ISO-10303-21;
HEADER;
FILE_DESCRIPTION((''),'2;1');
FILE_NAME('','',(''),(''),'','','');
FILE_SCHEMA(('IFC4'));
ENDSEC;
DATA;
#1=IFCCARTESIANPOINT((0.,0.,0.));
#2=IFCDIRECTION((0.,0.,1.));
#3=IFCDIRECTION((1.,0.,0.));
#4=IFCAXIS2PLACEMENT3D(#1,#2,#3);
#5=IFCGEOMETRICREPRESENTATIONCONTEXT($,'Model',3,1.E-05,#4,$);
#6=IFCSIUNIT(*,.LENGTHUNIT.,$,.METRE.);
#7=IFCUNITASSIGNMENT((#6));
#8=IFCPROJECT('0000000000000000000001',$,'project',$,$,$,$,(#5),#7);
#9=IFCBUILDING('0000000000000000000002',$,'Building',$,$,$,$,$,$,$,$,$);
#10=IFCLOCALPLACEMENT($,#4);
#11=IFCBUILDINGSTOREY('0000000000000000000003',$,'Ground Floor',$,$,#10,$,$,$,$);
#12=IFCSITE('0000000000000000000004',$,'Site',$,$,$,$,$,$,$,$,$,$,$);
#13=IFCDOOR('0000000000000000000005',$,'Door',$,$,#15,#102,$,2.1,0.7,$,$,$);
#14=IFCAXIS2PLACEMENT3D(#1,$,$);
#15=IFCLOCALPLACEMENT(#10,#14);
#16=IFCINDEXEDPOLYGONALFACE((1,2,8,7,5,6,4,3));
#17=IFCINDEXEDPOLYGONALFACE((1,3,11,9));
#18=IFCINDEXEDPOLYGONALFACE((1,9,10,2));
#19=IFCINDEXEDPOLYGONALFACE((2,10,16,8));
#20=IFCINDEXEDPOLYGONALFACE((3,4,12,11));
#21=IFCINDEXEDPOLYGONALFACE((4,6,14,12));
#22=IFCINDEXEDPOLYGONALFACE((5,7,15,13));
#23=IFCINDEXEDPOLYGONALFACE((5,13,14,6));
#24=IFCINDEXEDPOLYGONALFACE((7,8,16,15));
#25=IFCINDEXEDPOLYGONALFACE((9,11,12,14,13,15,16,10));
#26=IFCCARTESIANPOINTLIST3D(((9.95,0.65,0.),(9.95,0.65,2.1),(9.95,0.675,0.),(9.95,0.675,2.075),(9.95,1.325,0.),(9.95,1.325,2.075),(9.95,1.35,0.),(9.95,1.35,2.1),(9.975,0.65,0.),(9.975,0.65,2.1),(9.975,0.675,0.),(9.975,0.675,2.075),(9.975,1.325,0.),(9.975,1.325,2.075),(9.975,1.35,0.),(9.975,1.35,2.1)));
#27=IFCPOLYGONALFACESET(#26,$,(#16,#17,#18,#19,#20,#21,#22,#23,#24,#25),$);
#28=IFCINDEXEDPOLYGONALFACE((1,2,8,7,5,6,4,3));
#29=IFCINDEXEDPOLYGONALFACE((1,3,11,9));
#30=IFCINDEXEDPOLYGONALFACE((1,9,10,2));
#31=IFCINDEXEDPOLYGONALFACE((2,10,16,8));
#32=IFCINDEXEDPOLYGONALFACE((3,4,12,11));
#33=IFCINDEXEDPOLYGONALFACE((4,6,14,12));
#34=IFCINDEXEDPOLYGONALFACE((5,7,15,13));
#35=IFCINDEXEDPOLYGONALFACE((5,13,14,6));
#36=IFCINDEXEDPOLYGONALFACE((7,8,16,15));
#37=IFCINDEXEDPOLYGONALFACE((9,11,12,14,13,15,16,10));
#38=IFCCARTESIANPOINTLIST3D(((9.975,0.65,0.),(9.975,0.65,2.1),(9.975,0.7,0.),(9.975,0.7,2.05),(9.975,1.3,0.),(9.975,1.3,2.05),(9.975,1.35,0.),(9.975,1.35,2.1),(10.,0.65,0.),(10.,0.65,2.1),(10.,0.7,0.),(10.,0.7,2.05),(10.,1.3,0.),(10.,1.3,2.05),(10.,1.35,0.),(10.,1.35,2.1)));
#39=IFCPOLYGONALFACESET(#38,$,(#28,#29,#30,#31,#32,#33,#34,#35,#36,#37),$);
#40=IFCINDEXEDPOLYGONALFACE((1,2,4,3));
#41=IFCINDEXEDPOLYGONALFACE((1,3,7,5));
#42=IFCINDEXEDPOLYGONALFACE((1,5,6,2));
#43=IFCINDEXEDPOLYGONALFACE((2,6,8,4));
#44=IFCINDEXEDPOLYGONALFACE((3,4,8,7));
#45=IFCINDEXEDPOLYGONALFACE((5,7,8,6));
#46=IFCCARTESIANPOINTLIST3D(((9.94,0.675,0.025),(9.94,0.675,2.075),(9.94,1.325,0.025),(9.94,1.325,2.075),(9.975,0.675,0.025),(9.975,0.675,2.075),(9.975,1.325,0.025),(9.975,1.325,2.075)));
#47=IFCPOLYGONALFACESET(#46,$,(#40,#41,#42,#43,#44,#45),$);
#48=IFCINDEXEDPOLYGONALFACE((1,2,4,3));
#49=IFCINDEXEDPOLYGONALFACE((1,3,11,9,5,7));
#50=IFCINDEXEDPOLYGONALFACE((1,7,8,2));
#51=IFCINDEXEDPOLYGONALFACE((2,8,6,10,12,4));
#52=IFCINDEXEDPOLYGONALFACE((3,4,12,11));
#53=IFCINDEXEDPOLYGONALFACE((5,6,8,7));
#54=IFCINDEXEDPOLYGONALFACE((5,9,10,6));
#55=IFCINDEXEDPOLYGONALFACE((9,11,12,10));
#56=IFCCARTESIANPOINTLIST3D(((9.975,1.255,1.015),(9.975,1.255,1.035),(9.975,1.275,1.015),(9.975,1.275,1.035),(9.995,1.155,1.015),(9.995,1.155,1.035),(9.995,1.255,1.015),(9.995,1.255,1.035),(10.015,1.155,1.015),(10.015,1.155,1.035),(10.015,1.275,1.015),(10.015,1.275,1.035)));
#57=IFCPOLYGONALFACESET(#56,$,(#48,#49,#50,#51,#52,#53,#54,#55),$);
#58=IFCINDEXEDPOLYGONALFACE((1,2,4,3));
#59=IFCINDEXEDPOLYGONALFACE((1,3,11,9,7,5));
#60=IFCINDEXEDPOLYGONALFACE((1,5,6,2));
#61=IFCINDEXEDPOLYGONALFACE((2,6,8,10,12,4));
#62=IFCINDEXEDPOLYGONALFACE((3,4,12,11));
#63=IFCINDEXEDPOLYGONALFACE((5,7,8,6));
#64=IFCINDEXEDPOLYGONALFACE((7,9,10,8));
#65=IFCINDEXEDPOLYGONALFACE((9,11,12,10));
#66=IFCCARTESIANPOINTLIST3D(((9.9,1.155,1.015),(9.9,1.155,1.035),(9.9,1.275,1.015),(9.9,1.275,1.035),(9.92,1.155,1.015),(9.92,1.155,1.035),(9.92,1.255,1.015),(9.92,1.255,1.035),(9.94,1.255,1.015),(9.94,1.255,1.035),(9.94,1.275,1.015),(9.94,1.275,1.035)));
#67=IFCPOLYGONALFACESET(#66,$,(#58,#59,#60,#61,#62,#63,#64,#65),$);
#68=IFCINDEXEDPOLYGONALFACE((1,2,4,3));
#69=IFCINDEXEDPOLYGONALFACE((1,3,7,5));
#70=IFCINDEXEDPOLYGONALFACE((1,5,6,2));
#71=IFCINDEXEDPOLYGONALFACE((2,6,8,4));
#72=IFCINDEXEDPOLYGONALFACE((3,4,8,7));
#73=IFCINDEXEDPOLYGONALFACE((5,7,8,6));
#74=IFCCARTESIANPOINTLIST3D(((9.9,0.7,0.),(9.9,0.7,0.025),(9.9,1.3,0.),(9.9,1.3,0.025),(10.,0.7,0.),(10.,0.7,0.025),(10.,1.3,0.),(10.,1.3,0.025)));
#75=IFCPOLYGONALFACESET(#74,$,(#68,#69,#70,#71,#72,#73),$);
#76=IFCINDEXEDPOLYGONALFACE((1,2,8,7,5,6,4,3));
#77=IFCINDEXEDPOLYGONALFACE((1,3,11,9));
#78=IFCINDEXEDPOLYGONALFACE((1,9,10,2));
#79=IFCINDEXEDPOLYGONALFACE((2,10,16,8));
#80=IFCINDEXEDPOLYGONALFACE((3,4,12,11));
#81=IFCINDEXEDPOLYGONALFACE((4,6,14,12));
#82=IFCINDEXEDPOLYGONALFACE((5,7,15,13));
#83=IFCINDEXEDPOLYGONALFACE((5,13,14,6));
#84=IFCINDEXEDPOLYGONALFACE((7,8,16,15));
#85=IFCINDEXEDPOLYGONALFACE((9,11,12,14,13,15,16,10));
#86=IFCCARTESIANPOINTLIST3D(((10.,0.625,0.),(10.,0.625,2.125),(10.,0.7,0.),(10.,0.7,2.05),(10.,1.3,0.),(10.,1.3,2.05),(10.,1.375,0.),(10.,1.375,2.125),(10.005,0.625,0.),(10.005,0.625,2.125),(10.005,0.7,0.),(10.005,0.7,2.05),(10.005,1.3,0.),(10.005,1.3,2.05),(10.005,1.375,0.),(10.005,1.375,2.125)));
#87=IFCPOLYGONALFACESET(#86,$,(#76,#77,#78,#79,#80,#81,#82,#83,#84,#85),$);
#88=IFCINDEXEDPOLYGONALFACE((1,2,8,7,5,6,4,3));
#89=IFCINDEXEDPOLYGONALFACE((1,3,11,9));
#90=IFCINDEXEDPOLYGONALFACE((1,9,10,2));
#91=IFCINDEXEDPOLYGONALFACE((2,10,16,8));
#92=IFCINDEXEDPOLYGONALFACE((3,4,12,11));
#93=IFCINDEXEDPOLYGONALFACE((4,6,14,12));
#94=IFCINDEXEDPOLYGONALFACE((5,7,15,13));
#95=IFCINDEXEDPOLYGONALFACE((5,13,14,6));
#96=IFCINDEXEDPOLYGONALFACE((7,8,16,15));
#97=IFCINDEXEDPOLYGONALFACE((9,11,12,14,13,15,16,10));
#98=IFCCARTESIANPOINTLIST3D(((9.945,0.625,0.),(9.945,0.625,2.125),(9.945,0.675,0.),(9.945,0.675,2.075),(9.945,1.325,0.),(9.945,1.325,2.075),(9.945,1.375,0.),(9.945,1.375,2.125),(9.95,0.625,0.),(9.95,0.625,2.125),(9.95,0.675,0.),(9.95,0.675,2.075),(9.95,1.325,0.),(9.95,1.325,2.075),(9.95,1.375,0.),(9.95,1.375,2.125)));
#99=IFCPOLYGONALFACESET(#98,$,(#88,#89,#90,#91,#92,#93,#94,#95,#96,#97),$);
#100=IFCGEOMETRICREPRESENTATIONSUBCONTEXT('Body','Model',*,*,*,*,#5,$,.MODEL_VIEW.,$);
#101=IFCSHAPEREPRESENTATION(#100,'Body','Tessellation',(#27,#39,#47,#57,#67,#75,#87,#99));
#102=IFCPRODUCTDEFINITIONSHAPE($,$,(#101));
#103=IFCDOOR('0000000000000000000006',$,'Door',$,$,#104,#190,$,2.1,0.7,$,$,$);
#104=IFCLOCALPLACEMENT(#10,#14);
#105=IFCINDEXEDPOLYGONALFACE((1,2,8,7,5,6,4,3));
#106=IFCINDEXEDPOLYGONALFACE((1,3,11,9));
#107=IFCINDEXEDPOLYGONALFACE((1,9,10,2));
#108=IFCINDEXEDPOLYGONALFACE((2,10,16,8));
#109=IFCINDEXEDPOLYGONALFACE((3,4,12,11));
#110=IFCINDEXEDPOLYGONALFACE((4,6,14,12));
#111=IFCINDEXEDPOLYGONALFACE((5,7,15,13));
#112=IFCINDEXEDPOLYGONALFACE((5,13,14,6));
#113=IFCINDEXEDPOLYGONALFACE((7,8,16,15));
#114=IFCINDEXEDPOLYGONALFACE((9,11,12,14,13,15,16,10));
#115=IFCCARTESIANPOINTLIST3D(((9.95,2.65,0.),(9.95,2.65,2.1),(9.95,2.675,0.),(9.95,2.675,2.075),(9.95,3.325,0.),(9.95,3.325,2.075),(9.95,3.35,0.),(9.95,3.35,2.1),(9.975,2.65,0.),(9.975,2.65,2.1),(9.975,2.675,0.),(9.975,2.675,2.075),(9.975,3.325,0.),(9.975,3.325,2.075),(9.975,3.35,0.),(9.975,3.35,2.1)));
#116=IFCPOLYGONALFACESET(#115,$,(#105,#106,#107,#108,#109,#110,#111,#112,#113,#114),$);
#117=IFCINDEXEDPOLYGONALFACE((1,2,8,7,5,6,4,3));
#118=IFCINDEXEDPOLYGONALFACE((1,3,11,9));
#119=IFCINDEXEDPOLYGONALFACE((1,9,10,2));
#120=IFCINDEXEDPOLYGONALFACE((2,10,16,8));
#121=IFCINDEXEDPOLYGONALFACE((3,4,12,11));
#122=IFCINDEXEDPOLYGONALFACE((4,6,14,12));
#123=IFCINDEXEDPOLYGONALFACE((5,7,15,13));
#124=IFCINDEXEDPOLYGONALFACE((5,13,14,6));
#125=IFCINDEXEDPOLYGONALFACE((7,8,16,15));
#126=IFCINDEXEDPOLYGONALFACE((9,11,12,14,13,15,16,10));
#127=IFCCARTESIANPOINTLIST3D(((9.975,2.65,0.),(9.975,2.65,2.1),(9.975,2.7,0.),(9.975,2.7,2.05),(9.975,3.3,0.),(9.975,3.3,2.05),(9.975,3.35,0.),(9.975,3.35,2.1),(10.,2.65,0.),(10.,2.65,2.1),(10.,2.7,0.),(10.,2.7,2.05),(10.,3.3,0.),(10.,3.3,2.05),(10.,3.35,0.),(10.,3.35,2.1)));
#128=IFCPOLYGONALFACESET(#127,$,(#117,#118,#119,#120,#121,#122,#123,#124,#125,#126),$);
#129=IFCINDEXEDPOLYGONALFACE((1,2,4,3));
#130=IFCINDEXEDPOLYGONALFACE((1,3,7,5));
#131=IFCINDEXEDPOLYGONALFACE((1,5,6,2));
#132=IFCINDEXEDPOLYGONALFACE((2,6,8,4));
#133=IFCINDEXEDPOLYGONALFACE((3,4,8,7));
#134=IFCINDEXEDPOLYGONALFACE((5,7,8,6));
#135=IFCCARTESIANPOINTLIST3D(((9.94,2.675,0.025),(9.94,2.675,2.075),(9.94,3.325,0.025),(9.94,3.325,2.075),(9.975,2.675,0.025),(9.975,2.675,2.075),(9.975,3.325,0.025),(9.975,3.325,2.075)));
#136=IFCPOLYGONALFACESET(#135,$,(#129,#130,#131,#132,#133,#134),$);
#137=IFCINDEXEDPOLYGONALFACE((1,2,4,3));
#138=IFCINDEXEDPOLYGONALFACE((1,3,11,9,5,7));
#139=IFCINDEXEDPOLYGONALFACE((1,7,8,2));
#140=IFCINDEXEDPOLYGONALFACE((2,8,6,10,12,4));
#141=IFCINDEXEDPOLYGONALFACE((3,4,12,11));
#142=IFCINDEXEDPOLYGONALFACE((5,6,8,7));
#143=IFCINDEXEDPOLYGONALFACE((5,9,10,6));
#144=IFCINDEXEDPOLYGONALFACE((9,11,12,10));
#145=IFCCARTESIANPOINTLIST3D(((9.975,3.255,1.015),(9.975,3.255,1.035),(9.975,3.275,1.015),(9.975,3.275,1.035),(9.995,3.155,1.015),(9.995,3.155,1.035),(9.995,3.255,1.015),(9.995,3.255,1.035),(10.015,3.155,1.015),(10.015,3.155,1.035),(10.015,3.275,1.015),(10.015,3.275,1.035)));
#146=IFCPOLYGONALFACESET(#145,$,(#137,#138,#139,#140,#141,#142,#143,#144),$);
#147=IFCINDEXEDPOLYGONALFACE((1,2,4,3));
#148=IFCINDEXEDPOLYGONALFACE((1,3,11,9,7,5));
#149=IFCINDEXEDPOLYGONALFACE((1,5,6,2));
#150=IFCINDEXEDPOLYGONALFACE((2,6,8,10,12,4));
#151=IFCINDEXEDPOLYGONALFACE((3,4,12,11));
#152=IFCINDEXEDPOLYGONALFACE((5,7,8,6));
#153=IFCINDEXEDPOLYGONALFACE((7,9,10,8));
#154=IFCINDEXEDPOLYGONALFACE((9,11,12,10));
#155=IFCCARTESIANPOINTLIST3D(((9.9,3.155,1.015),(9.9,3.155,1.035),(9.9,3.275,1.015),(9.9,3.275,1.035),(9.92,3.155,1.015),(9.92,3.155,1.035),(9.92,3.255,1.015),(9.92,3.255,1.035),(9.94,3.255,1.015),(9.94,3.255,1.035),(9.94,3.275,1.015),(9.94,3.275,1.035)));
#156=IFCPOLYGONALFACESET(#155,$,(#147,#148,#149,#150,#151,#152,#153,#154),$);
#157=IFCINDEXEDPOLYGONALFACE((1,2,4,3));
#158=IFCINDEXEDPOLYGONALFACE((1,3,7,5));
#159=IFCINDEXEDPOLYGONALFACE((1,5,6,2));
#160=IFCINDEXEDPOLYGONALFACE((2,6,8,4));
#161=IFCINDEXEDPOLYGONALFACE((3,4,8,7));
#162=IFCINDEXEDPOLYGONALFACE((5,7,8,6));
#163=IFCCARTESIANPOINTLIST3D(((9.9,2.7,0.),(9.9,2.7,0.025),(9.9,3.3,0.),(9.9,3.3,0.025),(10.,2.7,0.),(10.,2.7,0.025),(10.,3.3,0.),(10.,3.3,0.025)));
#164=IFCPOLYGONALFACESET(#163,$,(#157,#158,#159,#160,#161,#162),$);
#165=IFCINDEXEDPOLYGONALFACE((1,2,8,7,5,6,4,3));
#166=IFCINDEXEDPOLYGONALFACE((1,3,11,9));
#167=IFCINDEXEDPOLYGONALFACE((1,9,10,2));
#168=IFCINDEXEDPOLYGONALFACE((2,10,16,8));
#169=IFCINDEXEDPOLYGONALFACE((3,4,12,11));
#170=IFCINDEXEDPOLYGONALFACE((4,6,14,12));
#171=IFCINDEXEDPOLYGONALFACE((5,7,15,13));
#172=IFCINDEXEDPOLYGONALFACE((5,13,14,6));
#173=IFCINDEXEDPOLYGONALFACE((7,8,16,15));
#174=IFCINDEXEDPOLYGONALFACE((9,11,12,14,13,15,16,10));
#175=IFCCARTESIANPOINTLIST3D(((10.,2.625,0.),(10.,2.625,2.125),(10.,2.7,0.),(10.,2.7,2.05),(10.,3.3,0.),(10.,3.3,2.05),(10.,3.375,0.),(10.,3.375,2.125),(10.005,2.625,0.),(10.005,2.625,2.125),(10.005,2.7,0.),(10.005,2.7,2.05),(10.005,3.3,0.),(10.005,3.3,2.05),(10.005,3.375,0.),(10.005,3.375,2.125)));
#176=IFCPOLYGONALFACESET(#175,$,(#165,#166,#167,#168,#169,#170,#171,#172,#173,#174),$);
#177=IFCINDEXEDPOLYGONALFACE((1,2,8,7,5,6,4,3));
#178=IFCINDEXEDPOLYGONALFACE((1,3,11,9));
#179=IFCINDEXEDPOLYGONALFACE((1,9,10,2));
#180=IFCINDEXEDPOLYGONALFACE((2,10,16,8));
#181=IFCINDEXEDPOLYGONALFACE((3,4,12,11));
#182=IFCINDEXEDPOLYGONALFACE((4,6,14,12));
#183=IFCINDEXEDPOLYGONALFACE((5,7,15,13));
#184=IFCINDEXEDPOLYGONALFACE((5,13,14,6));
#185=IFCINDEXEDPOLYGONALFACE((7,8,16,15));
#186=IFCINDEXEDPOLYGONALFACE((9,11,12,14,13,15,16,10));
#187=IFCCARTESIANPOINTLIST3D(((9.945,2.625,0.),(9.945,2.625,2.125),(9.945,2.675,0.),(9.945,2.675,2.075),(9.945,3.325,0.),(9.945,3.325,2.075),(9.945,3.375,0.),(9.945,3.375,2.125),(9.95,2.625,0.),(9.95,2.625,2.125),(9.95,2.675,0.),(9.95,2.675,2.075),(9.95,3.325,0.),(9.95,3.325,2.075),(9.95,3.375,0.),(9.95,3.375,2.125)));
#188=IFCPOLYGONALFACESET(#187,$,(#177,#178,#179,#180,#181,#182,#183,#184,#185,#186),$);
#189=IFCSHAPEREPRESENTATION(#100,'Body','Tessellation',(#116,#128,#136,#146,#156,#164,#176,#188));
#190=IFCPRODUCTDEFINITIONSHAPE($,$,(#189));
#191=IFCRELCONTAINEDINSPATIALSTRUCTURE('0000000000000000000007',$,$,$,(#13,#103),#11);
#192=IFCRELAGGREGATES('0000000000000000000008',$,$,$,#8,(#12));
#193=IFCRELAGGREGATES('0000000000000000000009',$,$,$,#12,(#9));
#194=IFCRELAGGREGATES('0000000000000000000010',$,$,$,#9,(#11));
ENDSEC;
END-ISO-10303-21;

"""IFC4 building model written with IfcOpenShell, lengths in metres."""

from ifc_helpers import new_model, si_unit, frame, origin_with_axes, place, context, subcontext, project, spatial, line, indexed_curve, outline, extrude, element, save


model = new_model("IFC4")

# Units and contexts
model_context = context("Model", 3, precision=1e-05, world=origin_with_axes())
body_context = subcontext(model_context, "Body", "Model", "MODEL_VIEW")
ifc_project = project(units=[si_unit("LENGTHUNIT", "METRE")], contexts=[model_context])

# Site, building, storey
site = spatial("IfcSite", under=ifc_project, Name="Site")
building = spatial("IfcBuilding", under=site, Name="Building")
storey_placement = place(None, origin_with_axes())
storey = spatial("IfcBuildingStorey", under=building, at=storey_placement, Name="Ground Floor")

# Doors
door_1_placement = place(storey_placement, frame((10.0, 0.65, 0.0), z_axis=(0.0, 0.0, 1.0), x_axis=(0.0, 1.0, 0.0)))
element("IfcDoor", 1, at=door_1_placement, inside=storey, Name="Door", OverallHeight=2.1, OverallWidth=0.7, context=body_context, shape_type="SweptSolid", body=[
    extrude(outline(indexed_curve([(0.0, 0.0), (0.0, 2.1), (0.7, 2.1), (0.7, 0.0), (0.675, 0.0), (0.675, 2.075), (0.025, 2.075), (0.025, 0.0)], segments=[line(1, 2, 3, 4, 5, 6, 7, 8, 1)])), frame((0.0, 0.025, 0.0), z_axis=(0.0, -1.0, 0.0), x_axis=(1.0, 0.0, 0.0)), (0.0, 0.0, -1.0), 0.025),
    extrude(outline(indexed_curve([(0.0, 0.0), (0.0, 2.1), (0.7, 2.1), (0.7, 0.0), (0.65, 0.0), (0.65, 2.05), (0.05, 2.05), (0.05, 0.0)], segments=[line(1, 2, 3, 4, 5, 6, 7, 8, 1)])), frame((0.0, 0.0, 0.0), z_axis=(0.0, -1.0, 0.0), x_axis=(1.0, 0.0, 0.0)), (0.0, 0.0, -1.0), 0.025),
    extrude(outline(indexed_curve([(0.0, 0.0), (0.65, 0.0), (0.65, 0.035), (0.0, 0.035)], segments=[line(1, 2, 3, 4, 1)])), frame((0.025, 0.025, 0.025), z_axis=(0.0, 0.0, 1.0), x_axis=(1.0, 0.0, 0.0)), (0.0, 0.0, 1.0), 2.05),
    extrude(outline(indexed_curve([(0.0, 0.0), (0.0, -0.04), (-0.12, -0.04), (-0.12, -0.02), (-0.02, -0.02), (-0.02, 0.0)], segments=[line(1, 2, 3, 4, 5, 6, 1)])), frame((0.625, 0.025, 1.015), z_axis=(0.0, 0.0, 1.0), x_axis=(1.0, 0.0, 0.0)), (0.0, 0.0, 1.0), 0.02),
    extrude(outline(indexed_curve([(0.0, 0.0), (0.0, 0.04), (-0.12, 0.04), (-0.12, 0.02), (-0.02, 0.02), (-0.02, 0.0)], segments=[line(1, 2, 3, 4, 5, 6, 1)])), frame((0.625, 0.06, 1.015), z_axis=(0.0, 0.0, 1.0), x_axis=(1.0, 0.0, 0.0)), (0.0, 0.0, 1.0), 0.02),
    extrude(outline(indexed_curve([(0.0, 0.0), (0.6, 0.0), (0.6, 0.1), (0.0, 0.1)], segments=[line(1, 2, 3, 4, 1)])), frame((0.05, 0.0, 0.0), z_axis=(0.0, 0.0, 1.0), x_axis=(1.0, 0.0, 0.0)), (0.0, 0.0, 1.0), 0.025),
    extrude(outline(indexed_curve([(0.0, 0.0), (0.0, 2.125), (0.75, 2.125), (0.75, 0.0), (0.675, 0.0), (0.675, 2.05), (0.075, 2.05), (0.075, 0.0)], segments=[line(1, 2, 3, 4, 5, 6, 7, 8, 1)])), frame((-0.025, -0.005, 0.0), z_axis=(0.0, -1.0, 0.0), x_axis=(1.0, 0.0, 0.0)), (0.0, 0.0, -1.0), 0.005),
    extrude(outline(indexed_curve([(0.0, 0.0), (0.0, 2.125), (0.75, 2.125), (0.75, 0.0), (0.7, 0.0), (0.7, 2.075), (0.05, 2.075), (0.05, 0.0)], segments=[line(1, 2, 3, 4, 5, 6, 7, 8, 1)])), frame((-0.025, 0.05, 0.0), z_axis=(0.0, -1.0, 0.0), x_axis=(1.0, 0.0, 0.0)), (0.0, 0.0, -1.0), 0.005),
])
door_2_placement = place(storey_placement, frame((10.0, 2.65, 0.0), z_axis=(0.0, 0.0, 1.0), x_axis=(0.0, 1.0, 0.0)))
element("IfcDoor", 2, at=door_2_placement, inside=storey, Name="Door", OverallHeight=2.1, OverallWidth=0.7, context=body_context, shape_type="SweptSolid", body=[
    extrude(outline(indexed_curve([(0.0, 0.0), (0.0, 2.1), (0.7, 2.1), (0.7, 0.0), (0.675, 0.0), (0.675, 2.075), (0.025, 2.075), (0.025, 0.0)], segments=[line(1, 2, 3, 4, 5, 6, 7, 8, 1)])), frame((0.0, 0.025, 0.0), z_axis=(0.0, -1.0, 0.0), x_axis=(1.0, 0.0, 0.0)), (0.0, 0.0, -1.0), 0.025),
    extrude(outline(indexed_curve([(0.0, 0.0), (0.0, 2.1), (0.7, 2.1), (0.7, 0.0), (0.65, 0.0), (0.65, 2.05), (0.05, 2.05), (0.05, 0.0)], segments=[line(1, 2, 3, 4, 5, 6, 7, 8, 1)])), frame((0.0, 0.0, 0.0), z_axis=(0.0, -1.0, 0.0), x_axis=(1.0, 0.0, 0.0)), (0.0, 0.0, -1.0), 0.025),
    extrude(outline(indexed_curve([(0.0, 0.0), (0.65, 0.0), (0.65, 0.035), (0.0, 0.035)], segments=[line(1, 2, 3, 4, 1)])), frame((0.025, 0.025, 0.025), z_axis=(0.0, 0.0, 1.0), x_axis=(1.0, 0.0, 0.0)), (0.0, 0.0, 1.0), 2.05),
    extrude(outline(indexed_curve([(0.0, 0.0), (0.0, -0.04), (-0.12, -0.04), (-0.12, -0.02), (-0.02, -0.02), (-0.02, 0.0)], segments=[line(1, 2, 3, 4, 5, 6, 1)])), frame((0.625, 0.025, 1.015), z_axis=(0.0, 0.0, 1.0), x_axis=(1.0, 0.0, 0.0)), (0.0, 0.0, 1.0), 0.02),
    extrude(outline(indexed_curve([(0.0, 0.0), (0.0, 0.04), (-0.12, 0.04), (-0.12, 0.02), (-0.02, 0.02), (-0.02, 0.0)], segments=[line(1, 2, 3, 4, 5, 6, 1)])), frame((0.625, 0.06, 1.015), z_axis=(0.0, 0.0, 1.0), x_axis=(1.0, 0.0, 0.0)), (0.0, 0.0, 1.0), 0.02),
    extrude(outline(indexed_curve([(0.0, 0.0), (0.6, 0.0), (0.6, 0.1), (0.0, 0.1)], segments=[line(1, 2, 3, 4, 1)])), frame((0.05, 0.0, 0.0), z_axis=(0.0, 0.0, 1.0), x_axis=(1.0, 0.0, 0.0)), (0.0, 0.0, 1.0), 0.025),
    extrude(outline(indexed_curve([(0.0, 0.0), (0.0, 2.125), (0.75, 2.125), (0.75, 0.0), (0.675, 0.0), (0.675, 2.05), (0.075, 2.05), (0.075, 0.0)], segments=[line(1, 2, 3, 4, 5, 6, 7, 8, 1)])), frame((-0.025, -0.005, 0.0), z_axis=(0.0, -1.0, 0.0), x_axis=(1.0, 0.0, 0.0)), (0.0, 0.0, -1.0), 0.005),
    extrude(outline(indexed_curve([(0.0, 0.0), (0.0, 2.125), (0.75, 2.125), (0.75, 0.0), (0.7, 0.0), (0.7, 2.075), (0.05, 2.075), (0.05, 0.0)], segments=[line(1, 2, 3, 4, 5, 6, 7, 8, 1)])), frame((-0.025, 0.05, 0.0), z_axis=(0.0, -1.0, 0.0), x_axis=(1.0, 0.0, 0.0)), (0.0, 0.0, -1.0), 0.005),
])

save(model, "model.ifc")
